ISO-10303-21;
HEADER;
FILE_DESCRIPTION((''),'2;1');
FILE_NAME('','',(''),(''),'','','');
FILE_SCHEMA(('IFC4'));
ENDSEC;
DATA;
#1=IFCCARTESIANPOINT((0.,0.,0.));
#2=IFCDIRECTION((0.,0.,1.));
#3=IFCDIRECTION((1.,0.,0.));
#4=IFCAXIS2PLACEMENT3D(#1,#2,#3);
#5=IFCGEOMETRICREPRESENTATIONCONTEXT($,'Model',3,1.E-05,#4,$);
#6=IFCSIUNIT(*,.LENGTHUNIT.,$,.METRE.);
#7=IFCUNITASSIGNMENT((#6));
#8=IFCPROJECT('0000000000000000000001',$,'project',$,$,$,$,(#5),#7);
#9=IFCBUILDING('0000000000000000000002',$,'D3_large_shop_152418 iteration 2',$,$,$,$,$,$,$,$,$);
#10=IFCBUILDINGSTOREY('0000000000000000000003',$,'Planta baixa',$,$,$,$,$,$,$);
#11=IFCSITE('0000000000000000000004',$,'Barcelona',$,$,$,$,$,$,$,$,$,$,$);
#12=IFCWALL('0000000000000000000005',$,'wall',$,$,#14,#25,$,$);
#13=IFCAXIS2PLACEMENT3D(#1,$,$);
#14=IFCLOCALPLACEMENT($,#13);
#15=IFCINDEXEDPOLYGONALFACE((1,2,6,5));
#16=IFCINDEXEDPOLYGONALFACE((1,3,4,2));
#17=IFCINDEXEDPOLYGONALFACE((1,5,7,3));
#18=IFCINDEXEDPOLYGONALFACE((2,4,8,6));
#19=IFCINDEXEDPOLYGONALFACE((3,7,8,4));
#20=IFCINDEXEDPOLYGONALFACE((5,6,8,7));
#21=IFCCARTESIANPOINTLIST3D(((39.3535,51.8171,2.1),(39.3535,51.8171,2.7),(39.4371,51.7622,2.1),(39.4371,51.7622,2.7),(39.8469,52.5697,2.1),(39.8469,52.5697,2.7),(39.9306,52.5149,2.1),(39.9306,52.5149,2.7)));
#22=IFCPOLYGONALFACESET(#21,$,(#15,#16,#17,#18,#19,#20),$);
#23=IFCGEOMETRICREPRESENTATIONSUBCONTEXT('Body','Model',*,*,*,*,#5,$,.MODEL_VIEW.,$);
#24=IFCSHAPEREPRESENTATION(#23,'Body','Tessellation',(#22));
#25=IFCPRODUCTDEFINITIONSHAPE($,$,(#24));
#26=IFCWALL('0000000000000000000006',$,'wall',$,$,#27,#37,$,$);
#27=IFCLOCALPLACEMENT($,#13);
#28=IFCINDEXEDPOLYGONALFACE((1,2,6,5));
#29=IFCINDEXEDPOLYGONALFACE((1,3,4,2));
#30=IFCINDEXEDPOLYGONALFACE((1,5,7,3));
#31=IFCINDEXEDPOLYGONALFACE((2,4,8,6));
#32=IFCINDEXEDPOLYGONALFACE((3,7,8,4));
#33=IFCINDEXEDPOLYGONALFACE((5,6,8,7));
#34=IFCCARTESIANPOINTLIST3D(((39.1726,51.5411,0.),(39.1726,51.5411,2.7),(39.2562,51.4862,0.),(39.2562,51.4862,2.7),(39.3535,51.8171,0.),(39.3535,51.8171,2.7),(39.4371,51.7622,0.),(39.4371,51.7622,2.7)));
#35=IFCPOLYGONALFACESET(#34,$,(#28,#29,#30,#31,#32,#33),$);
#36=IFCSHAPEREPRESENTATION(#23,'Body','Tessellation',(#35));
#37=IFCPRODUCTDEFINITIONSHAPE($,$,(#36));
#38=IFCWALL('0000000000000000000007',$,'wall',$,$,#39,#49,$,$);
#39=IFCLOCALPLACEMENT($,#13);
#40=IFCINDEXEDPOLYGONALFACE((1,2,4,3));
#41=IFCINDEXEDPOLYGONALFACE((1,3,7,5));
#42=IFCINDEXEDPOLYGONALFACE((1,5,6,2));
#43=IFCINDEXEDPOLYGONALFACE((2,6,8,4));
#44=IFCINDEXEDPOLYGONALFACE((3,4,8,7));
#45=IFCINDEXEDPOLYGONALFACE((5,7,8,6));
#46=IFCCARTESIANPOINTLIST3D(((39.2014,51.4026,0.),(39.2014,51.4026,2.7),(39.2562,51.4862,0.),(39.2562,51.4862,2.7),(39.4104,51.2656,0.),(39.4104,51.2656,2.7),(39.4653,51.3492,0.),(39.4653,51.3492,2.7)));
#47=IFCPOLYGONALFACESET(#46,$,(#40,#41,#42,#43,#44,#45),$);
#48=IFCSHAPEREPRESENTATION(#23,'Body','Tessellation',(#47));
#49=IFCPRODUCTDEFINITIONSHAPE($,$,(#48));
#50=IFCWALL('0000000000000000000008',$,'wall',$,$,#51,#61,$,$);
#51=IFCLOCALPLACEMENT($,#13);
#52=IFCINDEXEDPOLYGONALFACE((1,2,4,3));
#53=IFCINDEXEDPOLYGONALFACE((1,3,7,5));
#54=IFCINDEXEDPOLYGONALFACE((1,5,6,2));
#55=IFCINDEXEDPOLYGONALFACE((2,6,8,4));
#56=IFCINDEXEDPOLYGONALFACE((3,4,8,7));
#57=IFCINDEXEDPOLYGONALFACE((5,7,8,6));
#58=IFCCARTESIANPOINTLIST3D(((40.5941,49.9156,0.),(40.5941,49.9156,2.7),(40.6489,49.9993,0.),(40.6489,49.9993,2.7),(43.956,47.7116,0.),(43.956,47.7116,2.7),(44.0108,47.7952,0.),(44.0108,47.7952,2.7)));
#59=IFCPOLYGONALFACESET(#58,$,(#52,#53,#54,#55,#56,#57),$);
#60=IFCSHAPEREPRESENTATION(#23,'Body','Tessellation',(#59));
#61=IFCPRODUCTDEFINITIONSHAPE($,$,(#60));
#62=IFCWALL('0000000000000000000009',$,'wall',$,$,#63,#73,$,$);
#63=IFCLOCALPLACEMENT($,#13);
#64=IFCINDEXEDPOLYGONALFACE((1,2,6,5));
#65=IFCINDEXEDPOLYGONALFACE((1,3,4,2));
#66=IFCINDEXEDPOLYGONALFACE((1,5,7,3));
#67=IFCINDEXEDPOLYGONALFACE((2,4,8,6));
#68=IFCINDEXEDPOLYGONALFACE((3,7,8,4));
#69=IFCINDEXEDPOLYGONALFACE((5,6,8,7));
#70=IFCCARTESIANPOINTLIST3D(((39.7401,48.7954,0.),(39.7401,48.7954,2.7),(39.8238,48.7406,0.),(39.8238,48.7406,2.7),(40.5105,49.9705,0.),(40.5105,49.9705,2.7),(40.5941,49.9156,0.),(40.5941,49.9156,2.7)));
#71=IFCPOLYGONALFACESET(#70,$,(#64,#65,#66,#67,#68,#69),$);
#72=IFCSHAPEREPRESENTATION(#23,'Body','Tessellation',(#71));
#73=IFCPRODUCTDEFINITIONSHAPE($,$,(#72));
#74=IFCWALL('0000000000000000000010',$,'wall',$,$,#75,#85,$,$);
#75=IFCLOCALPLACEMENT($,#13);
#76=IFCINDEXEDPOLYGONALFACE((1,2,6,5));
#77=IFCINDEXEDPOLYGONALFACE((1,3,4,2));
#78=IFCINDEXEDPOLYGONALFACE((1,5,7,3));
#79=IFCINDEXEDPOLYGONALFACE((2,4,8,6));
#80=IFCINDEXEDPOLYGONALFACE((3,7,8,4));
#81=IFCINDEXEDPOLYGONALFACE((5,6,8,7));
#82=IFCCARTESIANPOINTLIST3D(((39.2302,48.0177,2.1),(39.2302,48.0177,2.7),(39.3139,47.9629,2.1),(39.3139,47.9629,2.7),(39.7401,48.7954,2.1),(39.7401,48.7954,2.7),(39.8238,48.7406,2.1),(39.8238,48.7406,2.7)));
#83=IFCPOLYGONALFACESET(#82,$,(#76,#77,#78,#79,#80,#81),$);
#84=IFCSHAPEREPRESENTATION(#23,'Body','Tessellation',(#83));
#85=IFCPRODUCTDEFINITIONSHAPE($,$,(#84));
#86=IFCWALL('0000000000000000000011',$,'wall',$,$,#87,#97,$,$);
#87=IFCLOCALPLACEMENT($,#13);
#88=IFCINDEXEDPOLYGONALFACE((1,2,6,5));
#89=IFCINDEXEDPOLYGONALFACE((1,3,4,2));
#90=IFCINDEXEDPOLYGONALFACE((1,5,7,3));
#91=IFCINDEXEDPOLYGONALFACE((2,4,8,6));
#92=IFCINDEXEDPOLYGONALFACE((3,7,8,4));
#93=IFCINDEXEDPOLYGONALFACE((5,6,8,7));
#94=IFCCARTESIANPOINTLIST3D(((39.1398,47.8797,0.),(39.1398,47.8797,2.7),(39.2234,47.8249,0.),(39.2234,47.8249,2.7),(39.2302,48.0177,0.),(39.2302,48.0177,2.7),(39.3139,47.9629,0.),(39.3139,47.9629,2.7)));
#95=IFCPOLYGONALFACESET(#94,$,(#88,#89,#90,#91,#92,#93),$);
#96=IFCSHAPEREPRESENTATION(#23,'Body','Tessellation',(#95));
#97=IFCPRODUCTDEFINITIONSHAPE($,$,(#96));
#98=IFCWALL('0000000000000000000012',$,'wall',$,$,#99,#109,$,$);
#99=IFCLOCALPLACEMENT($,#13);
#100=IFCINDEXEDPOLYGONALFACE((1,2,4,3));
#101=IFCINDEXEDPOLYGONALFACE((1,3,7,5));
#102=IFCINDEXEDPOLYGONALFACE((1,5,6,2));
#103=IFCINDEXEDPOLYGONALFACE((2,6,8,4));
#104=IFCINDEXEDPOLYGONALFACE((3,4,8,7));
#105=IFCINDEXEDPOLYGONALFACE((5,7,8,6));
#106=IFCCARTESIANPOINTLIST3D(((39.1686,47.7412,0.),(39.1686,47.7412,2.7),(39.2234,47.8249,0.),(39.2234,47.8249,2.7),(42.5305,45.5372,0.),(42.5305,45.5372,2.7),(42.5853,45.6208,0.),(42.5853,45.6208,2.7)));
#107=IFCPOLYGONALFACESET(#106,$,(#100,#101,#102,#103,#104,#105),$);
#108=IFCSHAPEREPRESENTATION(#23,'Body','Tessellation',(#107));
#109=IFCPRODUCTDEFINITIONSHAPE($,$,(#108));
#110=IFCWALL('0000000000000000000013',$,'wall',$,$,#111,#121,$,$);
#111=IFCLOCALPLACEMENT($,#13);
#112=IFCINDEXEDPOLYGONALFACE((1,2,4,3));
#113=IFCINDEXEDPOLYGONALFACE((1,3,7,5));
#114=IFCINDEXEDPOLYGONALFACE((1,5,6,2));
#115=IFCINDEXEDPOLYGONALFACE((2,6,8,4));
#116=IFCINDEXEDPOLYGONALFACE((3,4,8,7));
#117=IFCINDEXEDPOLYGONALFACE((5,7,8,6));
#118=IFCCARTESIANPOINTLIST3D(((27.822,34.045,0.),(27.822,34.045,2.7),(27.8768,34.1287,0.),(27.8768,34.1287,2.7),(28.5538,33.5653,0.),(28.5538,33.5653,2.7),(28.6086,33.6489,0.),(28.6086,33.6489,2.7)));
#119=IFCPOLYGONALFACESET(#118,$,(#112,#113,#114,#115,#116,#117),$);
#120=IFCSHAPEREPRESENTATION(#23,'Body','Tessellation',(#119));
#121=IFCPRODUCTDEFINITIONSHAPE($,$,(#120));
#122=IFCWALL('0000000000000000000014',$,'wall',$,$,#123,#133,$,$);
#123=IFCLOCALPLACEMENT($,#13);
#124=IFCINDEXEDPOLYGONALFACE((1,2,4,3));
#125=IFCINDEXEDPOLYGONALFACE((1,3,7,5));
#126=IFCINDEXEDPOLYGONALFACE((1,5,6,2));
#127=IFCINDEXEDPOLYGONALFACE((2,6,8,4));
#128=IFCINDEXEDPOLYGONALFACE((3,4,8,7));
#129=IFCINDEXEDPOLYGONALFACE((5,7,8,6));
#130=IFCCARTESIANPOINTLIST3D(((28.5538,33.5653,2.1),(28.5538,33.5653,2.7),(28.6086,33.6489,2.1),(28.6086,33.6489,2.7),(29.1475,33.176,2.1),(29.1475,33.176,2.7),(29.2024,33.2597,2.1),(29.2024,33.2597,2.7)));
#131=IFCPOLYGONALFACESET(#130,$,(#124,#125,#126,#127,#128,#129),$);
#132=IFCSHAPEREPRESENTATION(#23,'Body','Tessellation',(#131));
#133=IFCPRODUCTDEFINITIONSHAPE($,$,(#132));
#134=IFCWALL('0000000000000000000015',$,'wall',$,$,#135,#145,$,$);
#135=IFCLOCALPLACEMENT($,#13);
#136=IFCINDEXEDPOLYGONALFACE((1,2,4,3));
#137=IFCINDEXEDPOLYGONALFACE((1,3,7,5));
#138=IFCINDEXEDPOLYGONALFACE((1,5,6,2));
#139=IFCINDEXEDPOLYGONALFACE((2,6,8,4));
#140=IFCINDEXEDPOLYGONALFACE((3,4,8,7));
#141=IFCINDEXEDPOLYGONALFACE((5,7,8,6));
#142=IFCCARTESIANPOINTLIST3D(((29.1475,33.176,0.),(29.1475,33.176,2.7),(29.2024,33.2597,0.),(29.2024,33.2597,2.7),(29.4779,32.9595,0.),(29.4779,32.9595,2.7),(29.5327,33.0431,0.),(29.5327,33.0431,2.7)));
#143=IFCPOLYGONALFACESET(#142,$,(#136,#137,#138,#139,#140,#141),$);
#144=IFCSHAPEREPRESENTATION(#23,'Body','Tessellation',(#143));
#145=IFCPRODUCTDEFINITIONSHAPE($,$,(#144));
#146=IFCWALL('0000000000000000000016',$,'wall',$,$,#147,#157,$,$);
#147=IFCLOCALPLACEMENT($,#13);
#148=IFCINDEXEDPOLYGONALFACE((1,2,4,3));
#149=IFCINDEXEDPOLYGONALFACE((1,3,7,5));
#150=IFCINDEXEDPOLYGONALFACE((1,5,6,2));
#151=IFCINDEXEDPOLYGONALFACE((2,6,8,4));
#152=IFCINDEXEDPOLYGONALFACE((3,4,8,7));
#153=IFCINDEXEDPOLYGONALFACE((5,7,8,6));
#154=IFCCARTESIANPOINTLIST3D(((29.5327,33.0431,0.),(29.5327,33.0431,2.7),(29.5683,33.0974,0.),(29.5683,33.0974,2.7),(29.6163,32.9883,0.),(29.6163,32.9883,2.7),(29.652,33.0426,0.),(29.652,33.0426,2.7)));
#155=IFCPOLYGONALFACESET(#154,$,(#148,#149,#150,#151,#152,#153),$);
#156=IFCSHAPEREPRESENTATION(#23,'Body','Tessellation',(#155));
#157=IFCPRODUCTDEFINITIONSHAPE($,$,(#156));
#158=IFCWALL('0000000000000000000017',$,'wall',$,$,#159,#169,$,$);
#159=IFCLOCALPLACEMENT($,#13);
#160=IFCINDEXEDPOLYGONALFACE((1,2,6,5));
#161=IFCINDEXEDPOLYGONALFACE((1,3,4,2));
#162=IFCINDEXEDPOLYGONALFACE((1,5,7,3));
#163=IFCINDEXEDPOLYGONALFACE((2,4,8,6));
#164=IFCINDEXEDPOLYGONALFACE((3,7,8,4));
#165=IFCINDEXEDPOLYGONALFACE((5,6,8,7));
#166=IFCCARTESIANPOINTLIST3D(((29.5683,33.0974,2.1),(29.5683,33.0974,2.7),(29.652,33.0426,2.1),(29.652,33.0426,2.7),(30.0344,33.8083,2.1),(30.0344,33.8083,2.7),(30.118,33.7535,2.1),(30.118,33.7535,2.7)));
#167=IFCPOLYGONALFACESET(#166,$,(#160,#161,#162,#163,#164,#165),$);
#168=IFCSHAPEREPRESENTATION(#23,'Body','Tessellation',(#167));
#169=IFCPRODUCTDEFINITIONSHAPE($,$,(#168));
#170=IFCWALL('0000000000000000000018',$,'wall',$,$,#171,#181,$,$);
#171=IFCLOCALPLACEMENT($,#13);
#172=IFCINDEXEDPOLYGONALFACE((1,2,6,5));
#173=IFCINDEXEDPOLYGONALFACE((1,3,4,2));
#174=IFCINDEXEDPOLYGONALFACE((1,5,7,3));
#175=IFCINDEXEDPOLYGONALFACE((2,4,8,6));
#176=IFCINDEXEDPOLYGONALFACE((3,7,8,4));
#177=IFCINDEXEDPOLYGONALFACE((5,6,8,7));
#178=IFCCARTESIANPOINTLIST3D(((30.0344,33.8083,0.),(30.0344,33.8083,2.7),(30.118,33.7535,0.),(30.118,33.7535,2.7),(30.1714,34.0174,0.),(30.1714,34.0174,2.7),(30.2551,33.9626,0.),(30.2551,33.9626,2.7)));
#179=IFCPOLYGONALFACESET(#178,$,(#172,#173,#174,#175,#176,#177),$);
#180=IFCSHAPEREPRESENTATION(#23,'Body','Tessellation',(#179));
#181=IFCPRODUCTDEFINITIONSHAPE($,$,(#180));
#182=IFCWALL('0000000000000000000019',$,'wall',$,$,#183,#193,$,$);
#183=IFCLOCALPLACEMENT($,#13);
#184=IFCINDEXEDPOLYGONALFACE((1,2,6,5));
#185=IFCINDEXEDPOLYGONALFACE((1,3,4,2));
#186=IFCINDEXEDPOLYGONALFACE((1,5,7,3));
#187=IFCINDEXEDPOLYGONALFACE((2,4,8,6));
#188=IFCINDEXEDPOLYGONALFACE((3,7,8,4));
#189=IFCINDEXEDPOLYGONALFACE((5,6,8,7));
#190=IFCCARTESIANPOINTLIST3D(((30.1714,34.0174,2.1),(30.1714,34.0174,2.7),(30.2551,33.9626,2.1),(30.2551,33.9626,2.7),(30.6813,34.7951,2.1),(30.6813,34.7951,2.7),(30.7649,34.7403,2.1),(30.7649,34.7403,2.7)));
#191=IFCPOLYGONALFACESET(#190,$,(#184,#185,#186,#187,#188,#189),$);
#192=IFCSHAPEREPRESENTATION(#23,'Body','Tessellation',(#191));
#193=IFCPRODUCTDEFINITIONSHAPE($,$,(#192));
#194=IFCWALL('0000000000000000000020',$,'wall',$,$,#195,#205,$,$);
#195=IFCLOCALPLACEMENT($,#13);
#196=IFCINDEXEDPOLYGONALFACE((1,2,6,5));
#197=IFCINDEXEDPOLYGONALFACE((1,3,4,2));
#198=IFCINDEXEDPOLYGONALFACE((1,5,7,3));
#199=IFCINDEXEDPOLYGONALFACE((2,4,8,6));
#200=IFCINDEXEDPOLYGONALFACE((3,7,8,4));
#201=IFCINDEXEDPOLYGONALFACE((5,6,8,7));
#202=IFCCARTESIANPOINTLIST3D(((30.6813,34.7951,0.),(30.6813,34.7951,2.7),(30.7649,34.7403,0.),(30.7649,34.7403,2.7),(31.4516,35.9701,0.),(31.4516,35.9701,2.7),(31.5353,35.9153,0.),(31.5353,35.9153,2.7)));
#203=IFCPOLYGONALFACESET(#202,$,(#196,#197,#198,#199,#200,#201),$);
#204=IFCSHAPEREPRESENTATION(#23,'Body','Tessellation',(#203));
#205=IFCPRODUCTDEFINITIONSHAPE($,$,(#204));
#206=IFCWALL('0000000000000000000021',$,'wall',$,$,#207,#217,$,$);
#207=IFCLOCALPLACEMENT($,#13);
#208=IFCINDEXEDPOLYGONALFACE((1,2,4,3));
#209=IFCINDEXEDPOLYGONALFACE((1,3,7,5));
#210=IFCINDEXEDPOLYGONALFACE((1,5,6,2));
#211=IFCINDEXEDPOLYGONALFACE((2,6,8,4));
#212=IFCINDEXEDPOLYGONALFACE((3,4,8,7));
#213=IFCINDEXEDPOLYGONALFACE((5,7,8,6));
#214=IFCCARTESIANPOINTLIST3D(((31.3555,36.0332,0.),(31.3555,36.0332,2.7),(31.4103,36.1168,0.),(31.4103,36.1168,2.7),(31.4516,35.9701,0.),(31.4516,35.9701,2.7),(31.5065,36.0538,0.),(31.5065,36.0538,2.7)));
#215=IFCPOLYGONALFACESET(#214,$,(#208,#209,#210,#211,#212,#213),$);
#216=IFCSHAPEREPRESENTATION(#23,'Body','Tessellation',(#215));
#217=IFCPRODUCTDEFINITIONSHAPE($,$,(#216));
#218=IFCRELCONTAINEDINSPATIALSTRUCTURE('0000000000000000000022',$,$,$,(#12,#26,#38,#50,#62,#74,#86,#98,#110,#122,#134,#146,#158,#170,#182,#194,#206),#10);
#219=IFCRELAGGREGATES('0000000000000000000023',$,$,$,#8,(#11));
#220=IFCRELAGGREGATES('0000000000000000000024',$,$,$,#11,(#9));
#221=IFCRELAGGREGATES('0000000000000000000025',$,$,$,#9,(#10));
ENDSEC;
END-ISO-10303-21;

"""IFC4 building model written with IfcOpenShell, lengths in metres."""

from ifc_helpers import new_model, si_unit, frame, origin, origin_with_axes, place, context, subcontext, project, spatial, polyline, outline, extrude, element, save


model = new_model("IFC4")

# Units and contexts
model_context = context("Model", 3, precision=1e-05, world=origin_with_axes())
body_context = subcontext(model_context, "Body", "Model", "MODEL_VIEW")
ifc_project = project(units=[si_unit("LENGTHUNIT", "METRE")], contexts=[model_context])

# Site, building, storey
site = spatial("IfcSite", under=ifc_project, Name="Barcelona")
building = spatial("IfcBuilding", under=site, Name="D3_large_shop_152418 iteration 2")
storey = spatial("IfcBuildingStorey", under=building, Name="Planta baixa")

# Walls
wall_1_placement = place(None, origin_with_axes())
element("IfcWall", 1, at=wall_1_placement, inside=storey, Name="wall", context=body_context, shape_type="SweptSolid", body=[
    extrude(outline(polyline([(39.9306, 52.5149), (39.4371, 51.7622), (39.3535, 51.8171), (39.8469, 52.5697), (39.9306, 52.5149)])), frame((0.0, 0.0, 2.1)), (0.0, 0.0, 1.0), 0.6),
])
wall_2_placement = place(None, origin_with_axes())
element("IfcWall", 2, at=wall_2_placement, inside=storey, Name="wall", context=body_context, shape_type="SweptSolid", body=[
    extrude(outline(polyline([(39.4371, 51.7622), (39.2562, 51.4862), (39.1726, 51.5411), (39.3535, 51.8171), (39.4371, 51.7622)])), origin(), (0.0, 0.0, 1.0), 2.7),
])
wall_3_placement = place(None, origin_with_axes())
element("IfcWall", 3, at=wall_3_placement, inside=storey, Name="wall", context=body_context, shape_type="SweptSolid", body=[
    extrude(outline(polyline([(39.2562, 51.4862), (39.4653, 51.3492), (39.4104, 51.2656), (39.2014, 51.4026), (39.2562, 51.4862)])), origin(), (0.0, 0.0, 1.0), 2.7),
])
wall_4_placement = place(None, origin_with_axes())
element("IfcWall", 4, at=wall_4_placement, inside=storey, Name="wall", context=body_context, shape_type="SweptSolid", body=[
    extrude(outline(polyline([(43.956, 47.7116), (40.5941, 49.9156), (40.6489, 49.9993), (44.0108, 47.7952), (43.956, 47.7116)])), origin(), (0.0, 0.0, 1.0), 2.7),
])
wall_5_placement = place(None, origin_with_axes())
element("IfcWall", 5, at=wall_5_placement, inside=storey, Name="wall", context=body_context, shape_type="SweptSolid", body=[
    extrude(outline(polyline([(40.5941, 49.9156), (39.8238, 48.7406), (39.7401, 48.7954), (40.5105, 49.9705), (40.5941, 49.9156)])), origin(), (0.0, 0.0, 1.0), 2.7),
])
wall_6_placement = place(None, origin_with_axes())
element("IfcWall", 6, at=wall_6_placement, inside=storey, Name="wall", context=body_context, shape_type="SweptSolid", body=[
    extrude(outline(polyline([(39.8238, 48.7406), (39.3139, 47.9629), (39.2302, 48.0177), (39.7401, 48.7954), (39.8238, 48.7406)])), frame((0.0, 0.0, 2.1)), (0.0, 0.0, 1.0), 0.6),
])
wall_7_placement = place(None, origin_with_axes())
element("IfcWall", 7, at=wall_7_placement, inside=storey, Name="wall", context=body_context, shape_type="SweptSolid", body=[
    extrude(outline(polyline([(39.3139, 47.9629), (39.2234, 47.8249), (39.1398, 47.8797), (39.2302, 48.0177), (39.3139, 47.9629)])), origin(), (0.0, 0.0, 1.0), 2.7),
])
wall_8_placement = place(None, origin_with_axes())
element("IfcWall", 8, at=wall_8_placement, inside=storey, Name="wall", context=body_context, shape_type="SweptSolid", body=[
    extrude(outline(polyline([(39.2234, 47.8249), (42.5853, 45.6208), (42.5305, 45.5372), (39.1686, 47.7412), (39.2234, 47.8249)])), origin(), (0.0, 0.0, 1.0), 2.7),
])
wall_9_placement = place(None, origin_with_axes())
element("IfcWall", 9, at=wall_9_placement, inside=storey, Name="wall", context=body_context, shape_type="SweptSolid", body=[
    extrude(outline(polyline([(27.8768, 34.1287), (28.6086, 33.6489), (28.5538, 33.5653), (27.822, 34.045), (27.8768, 34.1287)])), origin(), (0.0, 0.0, 1.0), 2.7),
])
wall_10_placement = place(None, origin_with_axes())
element("IfcWall", 10, at=wall_10_placement, inside=storey, Name="wall", context=body_context, shape_type="SweptSolid", body=[
    extrude(outline(polyline([(28.6086, 33.6489), (29.2024, 33.2597), (29.1475, 33.176), (28.5538, 33.5653), (28.6086, 33.6489)])), frame((0.0, 0.0, 2.1)), (0.0, 0.0, 1.0), 0.6),
])
wall_11_placement = place(None, origin_with_axes())
element("IfcWall", 11, at=wall_11_placement, inside=storey, Name="wall", context=body_context, shape_type="SweptSolid", body=[
    extrude(outline(polyline([(29.2024, 33.2597), (29.5327, 33.0431), (29.4779, 32.9595), (29.1475, 33.176), (29.2024, 33.2597)])), origin(), (0.0, 0.0, 1.0), 2.7),
])
wall_12_placement = place(None, origin_with_axes())
element("IfcWall", 12, at=wall_12_placement, inside=storey, Name="wall", context=body_context, shape_type="SweptSolid", body=[
    extrude(outline(polyline([(29.5327, 33.0431), (29.5683, 33.0974), (29.652, 33.0426), (29.6163, 32.9883), (29.5327, 33.0431)])), origin(), (0.0, 0.0, 1.0), 2.7),
])
wall_13_placement = place(None, origin_with_axes())
element("IfcWall", 13, at=wall_13_placement, inside=storey, Name="wall", context=body_context, shape_type="SweptSolid", body=[
    extrude(outline(polyline([(29.5683, 33.0974), (30.0344, 33.8083), (30.118, 33.7535), (29.652, 33.0426), (29.5683, 33.0974)])), frame((0.0, 0.0, 2.1)), (0.0, 0.0, 1.0), 0.6),
])
wall_14_placement = place(None, origin_with_axes())
element("IfcWall", 14, at=wall_14_placement, inside=storey, Name="wall", context=body_context, shape_type="SweptSolid", body=[
    extrude(outline(polyline([(30.0344, 33.8083), (30.1714, 34.0174), (30.2551, 33.9626), (30.118, 33.7535), (30.0344, 33.8083)])), origin(), (0.0, 0.0, 1.0), 2.7),
])
wall_15_placement = place(None, origin_with_axes())
element("IfcWall", 15, at=wall_15_placement, inside=storey, Name="wall", context=body_context, shape_type="SweptSolid", body=[
    extrude(outline(polyline([(30.1714, 34.0174), (30.6813, 34.7951), (30.7649, 34.7403), (30.2551, 33.9626), (30.1714, 34.0174)])), frame((0.0, 0.0, 2.1)), (0.0, 0.0, 1.0), 0.6),
])
wall_16_placement = place(None, origin_with_axes())
element("IfcWall", 16, at=wall_16_placement, inside=storey, Name="wall", context=body_context, shape_type="SweptSolid", body=[
    extrude(outline(polyline([(30.6813, 34.7951), (31.4516, 35.9701), (31.5353, 35.9153), (30.7649, 34.7403), (30.6813, 34.7951)])), origin(), (0.0, 0.0, 1.0), 2.7),
])
wall_17_placement = place(None, origin_with_axes())
element("IfcWall", 17, at=wall_17_placement, inside=storey, Name="wall", context=body_context, shape_type="SweptSolid", body=[
    extrude(outline(polyline([(31.4516, 35.9701), (31.3555, 36.0332), (31.4103, 36.1168), (31.5065, 36.0538), (31.4516, 35.9701)])), origin(), (0.0, 0.0, 1.0), 2.7),
])

save(model, "model.ifc")
